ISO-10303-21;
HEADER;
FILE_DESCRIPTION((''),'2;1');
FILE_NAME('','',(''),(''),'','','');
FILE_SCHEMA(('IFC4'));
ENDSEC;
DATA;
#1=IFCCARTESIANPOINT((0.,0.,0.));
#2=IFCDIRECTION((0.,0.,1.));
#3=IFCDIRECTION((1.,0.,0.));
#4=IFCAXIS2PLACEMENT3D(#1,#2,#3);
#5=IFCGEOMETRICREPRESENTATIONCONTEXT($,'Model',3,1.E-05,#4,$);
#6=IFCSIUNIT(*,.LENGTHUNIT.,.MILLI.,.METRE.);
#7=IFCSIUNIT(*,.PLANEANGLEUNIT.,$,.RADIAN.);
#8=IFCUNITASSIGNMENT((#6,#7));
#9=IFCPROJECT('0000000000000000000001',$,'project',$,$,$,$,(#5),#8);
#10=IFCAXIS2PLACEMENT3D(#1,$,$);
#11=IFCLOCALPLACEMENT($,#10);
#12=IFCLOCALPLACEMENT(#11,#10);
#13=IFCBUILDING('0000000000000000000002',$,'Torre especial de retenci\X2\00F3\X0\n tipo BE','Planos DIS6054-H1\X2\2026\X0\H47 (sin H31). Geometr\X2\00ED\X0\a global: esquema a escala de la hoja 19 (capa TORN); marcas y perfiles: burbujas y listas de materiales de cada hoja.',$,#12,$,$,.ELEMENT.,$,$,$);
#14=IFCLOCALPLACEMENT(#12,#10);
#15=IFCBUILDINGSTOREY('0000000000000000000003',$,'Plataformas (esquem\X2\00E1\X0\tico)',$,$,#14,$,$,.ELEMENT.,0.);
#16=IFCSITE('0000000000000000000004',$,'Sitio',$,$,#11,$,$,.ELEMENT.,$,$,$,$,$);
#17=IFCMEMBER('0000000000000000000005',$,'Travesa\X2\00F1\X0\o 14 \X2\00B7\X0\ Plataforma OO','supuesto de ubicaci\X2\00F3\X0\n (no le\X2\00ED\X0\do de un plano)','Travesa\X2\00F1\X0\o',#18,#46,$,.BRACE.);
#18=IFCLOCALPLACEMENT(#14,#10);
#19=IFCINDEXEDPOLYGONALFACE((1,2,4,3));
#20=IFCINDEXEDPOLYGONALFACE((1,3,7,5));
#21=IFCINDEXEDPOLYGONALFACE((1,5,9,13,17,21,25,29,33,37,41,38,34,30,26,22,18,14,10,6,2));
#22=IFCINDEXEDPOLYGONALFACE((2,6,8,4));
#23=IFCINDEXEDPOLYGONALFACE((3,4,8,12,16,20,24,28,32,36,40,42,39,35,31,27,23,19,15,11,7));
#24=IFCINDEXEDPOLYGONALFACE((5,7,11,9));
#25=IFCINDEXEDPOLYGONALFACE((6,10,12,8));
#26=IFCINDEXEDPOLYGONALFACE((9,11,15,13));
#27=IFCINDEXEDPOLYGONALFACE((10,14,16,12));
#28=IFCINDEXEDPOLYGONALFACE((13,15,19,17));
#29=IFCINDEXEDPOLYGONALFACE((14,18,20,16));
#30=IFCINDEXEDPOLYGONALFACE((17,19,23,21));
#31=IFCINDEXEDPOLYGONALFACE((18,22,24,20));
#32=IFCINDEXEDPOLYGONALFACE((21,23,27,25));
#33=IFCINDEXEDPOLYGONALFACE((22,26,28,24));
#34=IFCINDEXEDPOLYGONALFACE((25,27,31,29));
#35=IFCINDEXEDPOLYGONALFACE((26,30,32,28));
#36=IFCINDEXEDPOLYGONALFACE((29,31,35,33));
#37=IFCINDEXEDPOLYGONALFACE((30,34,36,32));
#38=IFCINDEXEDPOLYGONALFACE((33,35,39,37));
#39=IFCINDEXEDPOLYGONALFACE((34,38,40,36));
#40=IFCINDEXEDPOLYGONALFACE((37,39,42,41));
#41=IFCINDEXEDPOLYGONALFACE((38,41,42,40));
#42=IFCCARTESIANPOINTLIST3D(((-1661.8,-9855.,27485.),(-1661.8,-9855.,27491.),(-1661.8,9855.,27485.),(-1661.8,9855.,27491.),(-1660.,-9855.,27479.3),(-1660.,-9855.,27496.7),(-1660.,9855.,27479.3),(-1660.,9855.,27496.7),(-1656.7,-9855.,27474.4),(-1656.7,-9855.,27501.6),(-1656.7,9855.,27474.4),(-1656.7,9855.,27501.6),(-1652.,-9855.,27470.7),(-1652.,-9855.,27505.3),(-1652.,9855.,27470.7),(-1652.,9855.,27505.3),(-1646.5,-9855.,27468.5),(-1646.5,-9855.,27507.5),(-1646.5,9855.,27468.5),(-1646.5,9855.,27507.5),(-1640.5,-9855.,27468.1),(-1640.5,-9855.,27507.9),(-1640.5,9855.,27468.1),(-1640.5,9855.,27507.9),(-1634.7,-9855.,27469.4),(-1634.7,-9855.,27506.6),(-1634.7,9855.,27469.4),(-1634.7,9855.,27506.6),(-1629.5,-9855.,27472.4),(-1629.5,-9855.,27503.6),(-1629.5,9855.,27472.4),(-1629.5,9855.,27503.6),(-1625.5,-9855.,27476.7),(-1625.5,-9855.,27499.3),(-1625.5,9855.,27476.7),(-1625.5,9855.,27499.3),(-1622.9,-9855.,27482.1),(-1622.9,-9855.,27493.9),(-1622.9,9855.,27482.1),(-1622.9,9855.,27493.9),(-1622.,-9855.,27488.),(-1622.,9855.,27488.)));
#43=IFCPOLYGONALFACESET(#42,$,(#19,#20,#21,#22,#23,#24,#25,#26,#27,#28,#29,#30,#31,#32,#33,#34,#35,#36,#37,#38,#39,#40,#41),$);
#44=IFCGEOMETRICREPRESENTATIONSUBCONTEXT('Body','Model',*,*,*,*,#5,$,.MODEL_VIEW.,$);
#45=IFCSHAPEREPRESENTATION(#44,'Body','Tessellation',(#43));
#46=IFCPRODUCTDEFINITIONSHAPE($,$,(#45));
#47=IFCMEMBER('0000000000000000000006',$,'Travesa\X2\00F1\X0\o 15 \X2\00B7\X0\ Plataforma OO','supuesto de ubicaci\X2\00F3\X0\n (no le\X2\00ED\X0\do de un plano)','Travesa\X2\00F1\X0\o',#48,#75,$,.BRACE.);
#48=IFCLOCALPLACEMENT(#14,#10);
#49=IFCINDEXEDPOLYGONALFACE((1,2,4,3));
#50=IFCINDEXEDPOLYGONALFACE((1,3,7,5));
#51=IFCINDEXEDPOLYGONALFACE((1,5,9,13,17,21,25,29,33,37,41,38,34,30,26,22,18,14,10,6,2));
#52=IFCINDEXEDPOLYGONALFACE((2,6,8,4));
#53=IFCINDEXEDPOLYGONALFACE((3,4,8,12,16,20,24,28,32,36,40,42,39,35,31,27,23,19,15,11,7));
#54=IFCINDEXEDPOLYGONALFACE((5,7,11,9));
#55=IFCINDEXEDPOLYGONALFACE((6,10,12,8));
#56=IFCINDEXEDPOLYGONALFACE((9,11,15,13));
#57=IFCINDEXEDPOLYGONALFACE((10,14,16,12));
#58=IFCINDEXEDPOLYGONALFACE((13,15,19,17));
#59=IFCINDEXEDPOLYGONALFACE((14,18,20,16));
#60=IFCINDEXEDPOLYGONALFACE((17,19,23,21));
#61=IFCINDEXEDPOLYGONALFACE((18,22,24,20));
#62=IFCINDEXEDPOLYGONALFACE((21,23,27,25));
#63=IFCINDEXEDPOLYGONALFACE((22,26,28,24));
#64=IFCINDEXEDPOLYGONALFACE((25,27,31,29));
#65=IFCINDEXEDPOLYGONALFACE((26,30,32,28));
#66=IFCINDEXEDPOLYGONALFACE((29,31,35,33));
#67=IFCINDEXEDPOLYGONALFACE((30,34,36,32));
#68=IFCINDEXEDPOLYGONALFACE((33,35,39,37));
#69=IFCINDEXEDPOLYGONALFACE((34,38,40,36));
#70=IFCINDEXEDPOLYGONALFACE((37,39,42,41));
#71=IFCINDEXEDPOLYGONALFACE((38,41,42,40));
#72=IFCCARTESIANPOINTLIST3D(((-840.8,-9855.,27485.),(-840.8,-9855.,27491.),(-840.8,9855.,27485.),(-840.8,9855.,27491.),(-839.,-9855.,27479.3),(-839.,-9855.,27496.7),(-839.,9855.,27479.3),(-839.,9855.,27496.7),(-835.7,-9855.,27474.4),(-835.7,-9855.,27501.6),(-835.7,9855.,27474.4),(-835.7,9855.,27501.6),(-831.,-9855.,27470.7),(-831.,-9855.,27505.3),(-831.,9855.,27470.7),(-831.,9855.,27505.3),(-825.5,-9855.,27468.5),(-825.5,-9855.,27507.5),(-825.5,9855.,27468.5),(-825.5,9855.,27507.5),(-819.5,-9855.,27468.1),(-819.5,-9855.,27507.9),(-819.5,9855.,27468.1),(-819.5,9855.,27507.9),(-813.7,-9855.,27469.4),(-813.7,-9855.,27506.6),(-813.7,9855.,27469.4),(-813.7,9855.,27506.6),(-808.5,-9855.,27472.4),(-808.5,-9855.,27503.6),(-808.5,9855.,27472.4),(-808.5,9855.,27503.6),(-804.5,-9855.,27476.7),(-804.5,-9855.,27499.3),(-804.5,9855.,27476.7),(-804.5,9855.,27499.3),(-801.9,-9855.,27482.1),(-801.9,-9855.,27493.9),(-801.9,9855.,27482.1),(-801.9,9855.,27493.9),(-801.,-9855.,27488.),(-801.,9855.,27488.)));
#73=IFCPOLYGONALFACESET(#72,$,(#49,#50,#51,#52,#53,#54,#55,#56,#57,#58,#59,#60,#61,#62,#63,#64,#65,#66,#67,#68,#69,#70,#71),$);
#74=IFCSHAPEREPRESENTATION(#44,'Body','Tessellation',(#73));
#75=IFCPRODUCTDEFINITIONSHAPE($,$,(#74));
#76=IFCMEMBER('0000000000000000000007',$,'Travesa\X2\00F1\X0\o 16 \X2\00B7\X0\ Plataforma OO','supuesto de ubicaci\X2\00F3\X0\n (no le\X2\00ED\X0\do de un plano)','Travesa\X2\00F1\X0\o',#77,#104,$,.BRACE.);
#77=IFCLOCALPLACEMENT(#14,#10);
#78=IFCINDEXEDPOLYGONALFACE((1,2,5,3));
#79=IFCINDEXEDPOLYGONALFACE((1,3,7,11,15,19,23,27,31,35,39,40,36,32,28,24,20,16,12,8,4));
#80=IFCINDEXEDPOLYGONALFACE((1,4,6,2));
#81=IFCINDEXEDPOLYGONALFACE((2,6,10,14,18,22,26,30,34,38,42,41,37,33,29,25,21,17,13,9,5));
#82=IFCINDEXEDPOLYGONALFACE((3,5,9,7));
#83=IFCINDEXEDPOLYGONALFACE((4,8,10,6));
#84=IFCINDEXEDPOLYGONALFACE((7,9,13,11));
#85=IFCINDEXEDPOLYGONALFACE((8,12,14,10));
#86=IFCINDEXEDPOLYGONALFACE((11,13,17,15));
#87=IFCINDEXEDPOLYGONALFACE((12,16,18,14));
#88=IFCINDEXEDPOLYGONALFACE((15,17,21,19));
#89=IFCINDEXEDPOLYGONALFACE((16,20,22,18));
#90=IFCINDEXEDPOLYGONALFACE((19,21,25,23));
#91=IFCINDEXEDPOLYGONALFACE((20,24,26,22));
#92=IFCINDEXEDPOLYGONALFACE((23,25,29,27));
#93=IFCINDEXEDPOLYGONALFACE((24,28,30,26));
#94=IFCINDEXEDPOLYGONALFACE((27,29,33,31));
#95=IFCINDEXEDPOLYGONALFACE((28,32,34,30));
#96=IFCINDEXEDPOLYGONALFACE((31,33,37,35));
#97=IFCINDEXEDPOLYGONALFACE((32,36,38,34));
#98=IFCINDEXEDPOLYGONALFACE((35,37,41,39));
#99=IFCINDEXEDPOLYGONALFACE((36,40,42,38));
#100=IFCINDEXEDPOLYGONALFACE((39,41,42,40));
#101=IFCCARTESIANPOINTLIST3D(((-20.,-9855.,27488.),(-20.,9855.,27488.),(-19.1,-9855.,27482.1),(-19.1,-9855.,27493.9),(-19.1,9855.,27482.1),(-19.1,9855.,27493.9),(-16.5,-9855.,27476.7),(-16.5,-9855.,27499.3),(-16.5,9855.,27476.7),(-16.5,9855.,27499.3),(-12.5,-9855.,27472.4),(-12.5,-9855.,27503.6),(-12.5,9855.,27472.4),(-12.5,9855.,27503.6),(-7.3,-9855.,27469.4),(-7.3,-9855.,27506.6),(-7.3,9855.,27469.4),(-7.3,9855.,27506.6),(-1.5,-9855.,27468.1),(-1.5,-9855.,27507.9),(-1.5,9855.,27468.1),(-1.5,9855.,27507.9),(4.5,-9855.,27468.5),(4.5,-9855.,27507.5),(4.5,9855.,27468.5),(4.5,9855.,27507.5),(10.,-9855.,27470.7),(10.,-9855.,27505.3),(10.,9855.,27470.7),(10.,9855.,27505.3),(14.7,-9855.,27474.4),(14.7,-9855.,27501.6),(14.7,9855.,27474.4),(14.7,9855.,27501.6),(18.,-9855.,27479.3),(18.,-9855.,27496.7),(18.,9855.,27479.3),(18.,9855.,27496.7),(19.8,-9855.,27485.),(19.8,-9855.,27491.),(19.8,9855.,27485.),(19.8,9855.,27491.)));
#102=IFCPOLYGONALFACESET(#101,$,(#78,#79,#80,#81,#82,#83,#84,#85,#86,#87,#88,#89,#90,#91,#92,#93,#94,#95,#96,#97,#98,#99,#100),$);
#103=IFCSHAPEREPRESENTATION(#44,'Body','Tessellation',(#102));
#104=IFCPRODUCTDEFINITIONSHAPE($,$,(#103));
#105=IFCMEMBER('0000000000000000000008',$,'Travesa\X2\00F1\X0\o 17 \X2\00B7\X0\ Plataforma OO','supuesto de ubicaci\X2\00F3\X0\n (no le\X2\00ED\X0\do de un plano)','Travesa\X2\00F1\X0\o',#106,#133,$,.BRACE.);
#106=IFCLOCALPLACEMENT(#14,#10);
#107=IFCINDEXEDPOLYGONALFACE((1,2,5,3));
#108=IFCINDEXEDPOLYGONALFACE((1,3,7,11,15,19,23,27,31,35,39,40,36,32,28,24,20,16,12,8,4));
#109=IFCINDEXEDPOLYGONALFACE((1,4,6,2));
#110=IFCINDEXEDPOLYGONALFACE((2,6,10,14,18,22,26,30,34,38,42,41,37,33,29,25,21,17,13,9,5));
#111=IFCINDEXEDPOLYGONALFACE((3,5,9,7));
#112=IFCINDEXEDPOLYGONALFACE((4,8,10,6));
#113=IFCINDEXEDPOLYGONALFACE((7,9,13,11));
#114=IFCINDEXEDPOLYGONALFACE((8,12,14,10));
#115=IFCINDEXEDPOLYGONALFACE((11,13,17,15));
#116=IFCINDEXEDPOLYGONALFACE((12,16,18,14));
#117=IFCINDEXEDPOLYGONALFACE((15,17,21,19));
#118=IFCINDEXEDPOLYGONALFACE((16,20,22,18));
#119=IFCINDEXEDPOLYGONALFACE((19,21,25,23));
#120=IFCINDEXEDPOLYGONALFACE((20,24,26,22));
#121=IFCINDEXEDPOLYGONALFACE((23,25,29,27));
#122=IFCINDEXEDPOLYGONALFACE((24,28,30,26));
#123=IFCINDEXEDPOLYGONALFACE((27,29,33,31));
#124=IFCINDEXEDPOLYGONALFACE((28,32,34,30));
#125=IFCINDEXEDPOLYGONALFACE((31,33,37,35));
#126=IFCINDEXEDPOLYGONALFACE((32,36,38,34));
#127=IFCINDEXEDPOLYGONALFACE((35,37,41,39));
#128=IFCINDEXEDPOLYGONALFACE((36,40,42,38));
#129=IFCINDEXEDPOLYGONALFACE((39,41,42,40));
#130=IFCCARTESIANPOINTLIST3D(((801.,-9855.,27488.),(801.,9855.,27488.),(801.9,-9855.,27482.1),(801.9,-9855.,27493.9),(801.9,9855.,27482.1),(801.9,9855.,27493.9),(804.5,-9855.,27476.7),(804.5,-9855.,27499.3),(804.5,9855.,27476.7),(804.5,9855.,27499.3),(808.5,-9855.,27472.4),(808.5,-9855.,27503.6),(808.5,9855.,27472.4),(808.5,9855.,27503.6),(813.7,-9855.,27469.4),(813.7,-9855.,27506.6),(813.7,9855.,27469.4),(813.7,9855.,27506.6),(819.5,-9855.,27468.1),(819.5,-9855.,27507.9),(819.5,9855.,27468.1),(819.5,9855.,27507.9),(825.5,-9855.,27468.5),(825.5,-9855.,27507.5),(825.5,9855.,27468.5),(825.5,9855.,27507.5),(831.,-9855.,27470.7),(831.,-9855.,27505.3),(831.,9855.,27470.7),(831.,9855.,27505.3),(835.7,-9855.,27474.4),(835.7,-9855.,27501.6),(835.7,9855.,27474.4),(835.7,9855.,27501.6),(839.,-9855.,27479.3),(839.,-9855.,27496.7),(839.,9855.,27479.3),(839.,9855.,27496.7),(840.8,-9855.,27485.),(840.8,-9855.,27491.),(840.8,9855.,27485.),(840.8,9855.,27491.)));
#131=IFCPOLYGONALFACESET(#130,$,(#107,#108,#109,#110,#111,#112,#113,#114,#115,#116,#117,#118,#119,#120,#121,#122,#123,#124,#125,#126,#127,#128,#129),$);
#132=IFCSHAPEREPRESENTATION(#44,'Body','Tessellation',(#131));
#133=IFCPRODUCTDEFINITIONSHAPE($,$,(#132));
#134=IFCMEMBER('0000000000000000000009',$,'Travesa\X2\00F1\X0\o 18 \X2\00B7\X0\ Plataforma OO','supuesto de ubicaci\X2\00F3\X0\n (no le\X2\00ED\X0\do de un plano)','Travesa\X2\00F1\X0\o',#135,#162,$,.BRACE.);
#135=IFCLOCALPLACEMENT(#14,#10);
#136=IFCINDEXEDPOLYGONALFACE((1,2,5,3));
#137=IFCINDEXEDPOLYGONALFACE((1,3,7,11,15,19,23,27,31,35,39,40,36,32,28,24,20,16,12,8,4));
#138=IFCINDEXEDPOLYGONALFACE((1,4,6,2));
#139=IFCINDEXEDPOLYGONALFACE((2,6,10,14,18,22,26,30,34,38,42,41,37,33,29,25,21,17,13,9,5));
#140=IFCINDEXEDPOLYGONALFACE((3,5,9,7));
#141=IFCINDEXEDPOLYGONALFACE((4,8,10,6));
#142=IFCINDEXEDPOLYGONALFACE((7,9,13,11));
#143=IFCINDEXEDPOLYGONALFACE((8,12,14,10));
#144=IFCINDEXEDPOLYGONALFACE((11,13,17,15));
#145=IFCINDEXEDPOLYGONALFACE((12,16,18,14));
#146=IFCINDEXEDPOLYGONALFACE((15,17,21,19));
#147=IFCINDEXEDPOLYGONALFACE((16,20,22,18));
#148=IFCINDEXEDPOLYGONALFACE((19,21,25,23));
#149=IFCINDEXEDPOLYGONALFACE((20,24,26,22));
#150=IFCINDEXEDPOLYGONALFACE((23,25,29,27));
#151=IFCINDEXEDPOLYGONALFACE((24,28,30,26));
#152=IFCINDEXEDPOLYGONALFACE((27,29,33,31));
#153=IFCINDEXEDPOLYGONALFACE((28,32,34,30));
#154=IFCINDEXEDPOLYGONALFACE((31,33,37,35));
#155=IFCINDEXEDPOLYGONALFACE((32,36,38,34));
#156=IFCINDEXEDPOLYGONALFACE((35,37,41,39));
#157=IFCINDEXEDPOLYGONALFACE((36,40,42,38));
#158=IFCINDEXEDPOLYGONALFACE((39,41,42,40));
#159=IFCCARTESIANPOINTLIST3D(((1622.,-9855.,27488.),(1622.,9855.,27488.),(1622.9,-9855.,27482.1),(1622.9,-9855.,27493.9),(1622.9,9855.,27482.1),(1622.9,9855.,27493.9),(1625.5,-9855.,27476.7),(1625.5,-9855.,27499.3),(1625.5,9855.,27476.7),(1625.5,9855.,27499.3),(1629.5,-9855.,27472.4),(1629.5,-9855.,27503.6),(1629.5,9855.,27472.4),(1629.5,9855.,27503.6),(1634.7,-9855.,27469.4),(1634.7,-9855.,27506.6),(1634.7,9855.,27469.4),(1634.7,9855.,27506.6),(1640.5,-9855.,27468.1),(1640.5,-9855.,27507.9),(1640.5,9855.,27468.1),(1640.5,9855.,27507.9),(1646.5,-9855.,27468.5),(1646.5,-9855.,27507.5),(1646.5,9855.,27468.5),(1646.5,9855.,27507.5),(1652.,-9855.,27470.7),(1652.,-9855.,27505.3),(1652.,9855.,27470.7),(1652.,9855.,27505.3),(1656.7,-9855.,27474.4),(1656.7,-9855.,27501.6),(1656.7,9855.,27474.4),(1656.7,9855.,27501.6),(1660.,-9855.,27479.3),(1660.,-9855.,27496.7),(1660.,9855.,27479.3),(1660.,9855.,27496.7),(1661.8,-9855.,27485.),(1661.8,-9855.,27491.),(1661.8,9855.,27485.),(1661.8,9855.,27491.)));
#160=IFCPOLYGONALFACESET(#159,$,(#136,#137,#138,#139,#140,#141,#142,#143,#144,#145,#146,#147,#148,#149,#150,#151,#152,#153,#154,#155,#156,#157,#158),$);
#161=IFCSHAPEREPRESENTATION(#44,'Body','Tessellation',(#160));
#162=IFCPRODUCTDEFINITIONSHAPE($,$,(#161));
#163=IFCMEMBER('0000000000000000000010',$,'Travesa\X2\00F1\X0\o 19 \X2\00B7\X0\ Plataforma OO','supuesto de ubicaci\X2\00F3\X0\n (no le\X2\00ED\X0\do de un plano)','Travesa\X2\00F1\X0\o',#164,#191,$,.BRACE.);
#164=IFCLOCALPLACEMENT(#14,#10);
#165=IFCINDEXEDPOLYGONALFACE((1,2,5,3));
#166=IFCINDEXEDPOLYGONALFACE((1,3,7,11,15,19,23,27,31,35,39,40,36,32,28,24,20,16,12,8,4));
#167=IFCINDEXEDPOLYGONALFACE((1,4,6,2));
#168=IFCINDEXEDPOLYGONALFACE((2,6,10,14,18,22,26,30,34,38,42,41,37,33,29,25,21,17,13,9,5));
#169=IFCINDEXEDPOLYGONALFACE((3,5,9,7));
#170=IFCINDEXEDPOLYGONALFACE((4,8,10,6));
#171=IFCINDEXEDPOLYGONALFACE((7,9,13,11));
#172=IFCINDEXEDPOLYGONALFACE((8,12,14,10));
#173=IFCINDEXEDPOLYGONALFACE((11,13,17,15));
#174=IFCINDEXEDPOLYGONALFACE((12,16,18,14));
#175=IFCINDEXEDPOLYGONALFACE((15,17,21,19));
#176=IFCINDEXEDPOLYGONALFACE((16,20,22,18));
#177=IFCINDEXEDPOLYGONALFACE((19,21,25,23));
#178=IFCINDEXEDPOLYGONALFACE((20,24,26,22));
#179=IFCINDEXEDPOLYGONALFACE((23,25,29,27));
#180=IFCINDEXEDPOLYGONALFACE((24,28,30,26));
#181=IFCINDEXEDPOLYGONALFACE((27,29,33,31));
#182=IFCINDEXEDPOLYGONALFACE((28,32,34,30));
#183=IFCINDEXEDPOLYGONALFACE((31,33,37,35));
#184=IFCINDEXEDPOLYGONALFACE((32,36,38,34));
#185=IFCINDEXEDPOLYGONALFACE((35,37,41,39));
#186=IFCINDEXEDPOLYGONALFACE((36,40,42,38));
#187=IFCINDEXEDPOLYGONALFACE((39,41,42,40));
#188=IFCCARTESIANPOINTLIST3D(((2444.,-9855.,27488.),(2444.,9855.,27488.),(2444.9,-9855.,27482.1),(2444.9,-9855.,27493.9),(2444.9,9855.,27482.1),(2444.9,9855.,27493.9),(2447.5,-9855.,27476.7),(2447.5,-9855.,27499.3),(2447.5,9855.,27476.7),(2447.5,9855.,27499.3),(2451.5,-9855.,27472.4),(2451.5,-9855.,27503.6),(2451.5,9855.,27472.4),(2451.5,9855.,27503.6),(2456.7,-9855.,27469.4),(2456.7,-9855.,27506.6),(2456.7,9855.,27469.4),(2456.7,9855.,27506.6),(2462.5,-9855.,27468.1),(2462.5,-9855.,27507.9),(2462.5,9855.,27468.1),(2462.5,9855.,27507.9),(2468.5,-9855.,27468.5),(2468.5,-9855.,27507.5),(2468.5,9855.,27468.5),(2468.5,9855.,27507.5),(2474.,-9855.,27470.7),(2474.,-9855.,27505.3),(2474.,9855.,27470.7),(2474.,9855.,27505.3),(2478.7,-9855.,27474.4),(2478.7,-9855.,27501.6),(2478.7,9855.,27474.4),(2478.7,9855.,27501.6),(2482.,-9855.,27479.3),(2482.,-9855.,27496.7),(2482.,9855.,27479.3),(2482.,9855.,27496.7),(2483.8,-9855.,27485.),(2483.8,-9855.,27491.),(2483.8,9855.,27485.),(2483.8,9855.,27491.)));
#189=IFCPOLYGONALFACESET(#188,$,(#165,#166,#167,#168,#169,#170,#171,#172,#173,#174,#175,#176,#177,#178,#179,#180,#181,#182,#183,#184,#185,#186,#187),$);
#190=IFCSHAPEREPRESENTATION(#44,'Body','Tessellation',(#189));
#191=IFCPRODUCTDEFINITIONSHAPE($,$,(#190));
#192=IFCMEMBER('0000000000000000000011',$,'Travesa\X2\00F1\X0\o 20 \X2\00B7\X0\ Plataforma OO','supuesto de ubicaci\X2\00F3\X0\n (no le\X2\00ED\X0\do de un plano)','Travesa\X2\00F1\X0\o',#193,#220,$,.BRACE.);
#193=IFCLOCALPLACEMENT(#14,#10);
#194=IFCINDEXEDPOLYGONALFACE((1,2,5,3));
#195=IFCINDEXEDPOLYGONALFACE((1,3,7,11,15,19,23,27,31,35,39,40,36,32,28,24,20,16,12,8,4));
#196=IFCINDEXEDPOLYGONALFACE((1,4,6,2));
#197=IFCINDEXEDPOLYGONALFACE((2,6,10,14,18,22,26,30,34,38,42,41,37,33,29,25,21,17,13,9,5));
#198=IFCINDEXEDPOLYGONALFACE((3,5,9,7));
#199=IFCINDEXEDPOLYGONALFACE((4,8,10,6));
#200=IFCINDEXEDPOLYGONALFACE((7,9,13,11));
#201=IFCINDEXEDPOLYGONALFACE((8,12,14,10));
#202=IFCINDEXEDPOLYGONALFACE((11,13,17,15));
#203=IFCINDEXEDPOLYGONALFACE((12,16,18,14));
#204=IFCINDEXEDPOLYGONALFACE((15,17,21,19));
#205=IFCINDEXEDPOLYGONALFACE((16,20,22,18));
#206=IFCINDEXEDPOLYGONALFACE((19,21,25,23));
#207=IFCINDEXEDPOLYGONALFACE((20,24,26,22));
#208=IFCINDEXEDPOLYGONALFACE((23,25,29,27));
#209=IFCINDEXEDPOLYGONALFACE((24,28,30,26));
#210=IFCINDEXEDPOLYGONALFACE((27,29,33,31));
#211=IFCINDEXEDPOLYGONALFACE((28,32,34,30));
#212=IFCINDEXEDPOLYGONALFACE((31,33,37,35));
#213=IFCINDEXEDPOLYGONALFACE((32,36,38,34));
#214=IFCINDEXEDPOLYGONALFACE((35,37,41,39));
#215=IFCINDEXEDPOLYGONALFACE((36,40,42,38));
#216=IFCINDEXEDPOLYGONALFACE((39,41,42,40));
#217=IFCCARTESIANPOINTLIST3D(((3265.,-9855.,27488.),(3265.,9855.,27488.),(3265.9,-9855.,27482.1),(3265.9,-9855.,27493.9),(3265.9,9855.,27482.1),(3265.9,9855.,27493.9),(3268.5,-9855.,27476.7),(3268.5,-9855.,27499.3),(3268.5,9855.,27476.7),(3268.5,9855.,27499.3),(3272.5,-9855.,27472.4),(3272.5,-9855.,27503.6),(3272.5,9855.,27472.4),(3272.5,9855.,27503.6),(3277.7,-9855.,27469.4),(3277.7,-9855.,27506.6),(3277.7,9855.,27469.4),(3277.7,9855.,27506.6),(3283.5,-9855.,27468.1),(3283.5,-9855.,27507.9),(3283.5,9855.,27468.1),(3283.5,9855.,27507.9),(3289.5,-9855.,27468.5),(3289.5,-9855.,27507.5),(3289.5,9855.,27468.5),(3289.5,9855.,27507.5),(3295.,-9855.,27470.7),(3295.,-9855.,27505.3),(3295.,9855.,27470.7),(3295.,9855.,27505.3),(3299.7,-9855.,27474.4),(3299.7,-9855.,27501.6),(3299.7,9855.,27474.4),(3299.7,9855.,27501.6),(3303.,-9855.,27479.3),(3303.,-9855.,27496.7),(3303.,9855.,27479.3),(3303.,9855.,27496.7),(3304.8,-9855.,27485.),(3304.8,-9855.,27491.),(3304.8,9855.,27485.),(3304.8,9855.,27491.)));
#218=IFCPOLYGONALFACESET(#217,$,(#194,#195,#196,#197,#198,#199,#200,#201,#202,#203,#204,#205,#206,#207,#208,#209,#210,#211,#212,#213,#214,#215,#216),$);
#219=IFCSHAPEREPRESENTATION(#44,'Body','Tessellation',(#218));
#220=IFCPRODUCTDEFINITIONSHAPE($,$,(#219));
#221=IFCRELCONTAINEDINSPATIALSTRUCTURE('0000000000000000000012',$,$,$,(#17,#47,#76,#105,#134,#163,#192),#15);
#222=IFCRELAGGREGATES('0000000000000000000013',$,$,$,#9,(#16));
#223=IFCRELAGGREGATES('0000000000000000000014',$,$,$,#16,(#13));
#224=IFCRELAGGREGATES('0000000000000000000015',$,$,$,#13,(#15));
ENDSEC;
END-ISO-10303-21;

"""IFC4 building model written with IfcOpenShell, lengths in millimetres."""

from ifc_helpers import new_model, si_unit, frame, origin, origin_with_axes, place, context, subcontext, project, spatial, circle, extrude, element, save


model = new_model("IFC4")

# Units and contexts
model_context = context("Model", 3, precision=1e-05, world=origin_with_axes())
body_context = subcontext(model_context, "Body", "Model", "MODEL_VIEW")
ifc_project = project(units=[si_unit("LENGTHUNIT", "METRE", prefix="MILLI"), si_unit("PLANEANGLEUNIT", "RADIAN")], contexts=[model_context])

# Site, building, storey
site_placement = place(None, origin())
site = spatial("IfcSite", under=ifc_project, at=site_placement, Name="Sitio", CompositionType="ELEMENT")
building_placement = place(site_placement, origin())
building = spatial("IfcBuilding", under=site, at=building_placement, Name="Torre especial de retención tipo BE", Description="Planos DIS6054-H1…H47 (sin H31). Geometría global: esquema a escala de la hoja 19 (capa TORN); marcas y perfiles: burbujas y listas de materiales de cada hoja.", CompositionType="ELEMENT")
storey_placement = place(building_placement, origin())
storey = spatial("IfcBuildingStorey", under=building, at=storey_placement, Name="Plataformas (esquemático)", CompositionType="ELEMENT", Elevation=0.0)

# Members
for number, where, z_axis, x_axis, name in (
    (1, (-1642.0, 9855.0, 27488.0), (0.0, -1.0, 0.0), (1.0, 0.0, 0.0), "Travesaño 14 · Plataforma OO"),
    (2, (-821.0, 9855.0, 27488.0), (0.0, -1.0, 0.0), (1.0, 0.0, 0.0), "Travesaño 15 · Plataforma OO"),
    (3, (0.0, 9855.0, 27488.0), (0.0, -1.0, 0.0), (-1.0, 0.0, 0.0), "Travesaño 16 · Plataforma OO"),
    (4, (821.0, 9855.0, 27488.0), (0.0, -1.0, 0.0), (-1.0, 0.0, 0.0), "Travesaño 17 · Plataforma OO"),
    (5, (1642.0, 9855.0, 27488.0), (0.0, -1.0, 0.0), (-1.0, 0.0, 0.0), "Travesaño 18 · Plataforma OO"),
    (6, (2464.0, 9855.0, 27488.0), (0.0, -1.0, 0.0), (-1.0, 0.0, 0.0), "Travesaño 19 · Plataforma OO"),
    (7, (3285.0, 9855.0, 27488.0), (0.0, -1.0, 0.0), (-1.0, 0.0, 0.0), "Travesaño 20 · Plataforma OO"),
):
    element("IfcMember", number, at=place(storey_placement, frame(where, z_axis=z_axis, x_axis=x_axis)), inside=storey, Name=name, Description="supuesto de ubicación (no leído de un plano)", ObjectType="Travesaño", PredefinedType="BRACE", context=body_context, shape_type="SweptSolid", body=[
        extrude(circle(Radius=20.0), None, (0.0, 0.0, 1.0), 19710.0),
    ])

save(model, "model.ifc")
